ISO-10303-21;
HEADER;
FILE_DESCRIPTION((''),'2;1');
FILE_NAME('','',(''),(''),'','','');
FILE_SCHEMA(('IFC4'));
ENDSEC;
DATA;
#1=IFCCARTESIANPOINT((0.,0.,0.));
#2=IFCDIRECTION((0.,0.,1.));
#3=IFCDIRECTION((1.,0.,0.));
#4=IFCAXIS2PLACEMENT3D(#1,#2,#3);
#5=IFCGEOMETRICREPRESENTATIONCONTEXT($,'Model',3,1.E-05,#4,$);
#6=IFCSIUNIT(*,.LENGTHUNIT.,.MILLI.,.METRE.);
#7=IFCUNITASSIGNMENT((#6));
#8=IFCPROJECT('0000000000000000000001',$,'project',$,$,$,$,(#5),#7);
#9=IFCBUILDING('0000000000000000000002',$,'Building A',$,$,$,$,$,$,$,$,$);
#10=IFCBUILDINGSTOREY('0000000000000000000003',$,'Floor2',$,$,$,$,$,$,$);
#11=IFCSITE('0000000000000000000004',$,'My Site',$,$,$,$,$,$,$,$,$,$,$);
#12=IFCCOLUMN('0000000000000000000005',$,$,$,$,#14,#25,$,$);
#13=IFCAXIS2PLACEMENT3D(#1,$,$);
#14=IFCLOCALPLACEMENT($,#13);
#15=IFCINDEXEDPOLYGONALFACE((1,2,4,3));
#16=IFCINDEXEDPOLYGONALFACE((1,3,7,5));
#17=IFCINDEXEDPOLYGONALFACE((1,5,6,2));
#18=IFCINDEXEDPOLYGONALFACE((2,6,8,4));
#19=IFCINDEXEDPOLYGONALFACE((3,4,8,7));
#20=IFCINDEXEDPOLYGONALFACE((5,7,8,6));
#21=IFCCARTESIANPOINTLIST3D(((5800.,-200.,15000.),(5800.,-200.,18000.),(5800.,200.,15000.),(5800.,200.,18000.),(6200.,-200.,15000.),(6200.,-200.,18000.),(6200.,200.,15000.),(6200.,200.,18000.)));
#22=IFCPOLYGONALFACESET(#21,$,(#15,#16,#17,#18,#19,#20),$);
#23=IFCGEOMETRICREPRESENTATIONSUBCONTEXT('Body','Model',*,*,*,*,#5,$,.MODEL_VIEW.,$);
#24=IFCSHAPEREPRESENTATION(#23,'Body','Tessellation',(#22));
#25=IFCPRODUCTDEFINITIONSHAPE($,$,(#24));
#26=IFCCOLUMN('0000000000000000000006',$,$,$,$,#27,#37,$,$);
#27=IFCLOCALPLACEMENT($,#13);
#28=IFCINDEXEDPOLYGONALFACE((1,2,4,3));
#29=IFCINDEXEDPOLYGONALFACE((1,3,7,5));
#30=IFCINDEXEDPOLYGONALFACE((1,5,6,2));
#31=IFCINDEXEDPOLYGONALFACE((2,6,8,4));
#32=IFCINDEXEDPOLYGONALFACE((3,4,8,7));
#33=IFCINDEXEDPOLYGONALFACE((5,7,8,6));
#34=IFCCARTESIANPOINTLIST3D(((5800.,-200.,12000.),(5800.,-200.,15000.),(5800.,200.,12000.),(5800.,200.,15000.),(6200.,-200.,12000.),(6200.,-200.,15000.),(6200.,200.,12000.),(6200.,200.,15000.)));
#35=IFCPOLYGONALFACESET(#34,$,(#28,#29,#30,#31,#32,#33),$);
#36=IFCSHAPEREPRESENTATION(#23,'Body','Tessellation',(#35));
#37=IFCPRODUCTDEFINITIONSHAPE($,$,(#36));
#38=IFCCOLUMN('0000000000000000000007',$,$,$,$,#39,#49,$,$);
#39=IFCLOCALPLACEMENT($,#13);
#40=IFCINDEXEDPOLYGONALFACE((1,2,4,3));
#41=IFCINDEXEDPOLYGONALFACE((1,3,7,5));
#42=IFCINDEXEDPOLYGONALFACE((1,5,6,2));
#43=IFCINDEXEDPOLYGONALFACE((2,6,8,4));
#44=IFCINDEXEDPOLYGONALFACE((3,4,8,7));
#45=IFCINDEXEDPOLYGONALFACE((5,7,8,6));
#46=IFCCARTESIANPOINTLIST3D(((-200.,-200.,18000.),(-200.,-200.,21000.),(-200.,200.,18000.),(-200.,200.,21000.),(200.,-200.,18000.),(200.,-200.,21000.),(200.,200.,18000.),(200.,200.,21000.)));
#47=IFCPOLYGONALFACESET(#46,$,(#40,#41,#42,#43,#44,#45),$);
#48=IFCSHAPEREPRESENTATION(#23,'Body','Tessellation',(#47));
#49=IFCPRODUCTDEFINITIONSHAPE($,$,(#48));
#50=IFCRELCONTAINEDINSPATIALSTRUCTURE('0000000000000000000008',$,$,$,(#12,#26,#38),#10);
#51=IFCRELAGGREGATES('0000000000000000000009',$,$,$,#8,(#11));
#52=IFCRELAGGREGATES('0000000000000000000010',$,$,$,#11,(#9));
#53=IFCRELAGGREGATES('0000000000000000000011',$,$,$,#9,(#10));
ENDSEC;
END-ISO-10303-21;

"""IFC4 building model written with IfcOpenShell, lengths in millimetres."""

from ifc_helpers import new_model, si_unit, frame, origin_with_axes, place, context, subcontext, project, spatial, line, indexed_curve, outline, extrude, element, save


model = new_model("IFC4")

# Units and contexts
model_context = context("Model", 3, precision=1e-05, world=origin_with_axes())
body_context = subcontext(model_context, "Body", "Model", "MODEL_VIEW")
ifc_project = project(units=[si_unit("LENGTHUNIT", "METRE", prefix="MILLI")], contexts=[model_context])

# Site, building, storey
site = spatial("IfcSite", under=ifc_project, Name="My Site")
building = spatial("IfcBuilding", under=site, Name="Building A")
storey = spatial("IfcBuildingStorey", under=building, Name="Floor2")

# Columns
for number, where, z_axis, x_axis in (
    (1, (6000.0, 0.0, 15000.0), (0.0, 0.0, 1.0), (1.0, 0.0, 0.0)),
    (2, (6000.0, 0.0, 12000.0), (0.0, 0.0, 1.0), (1.0, 0.0, 0.0)),
    (3, (0.0, 0.0, 18000.0), (0.0, 0.0, 1.0), (1.0, 0.0, 0.0)),
):
    element("IfcColumn", number, at=place(None, frame(where, z_axis=z_axis, x_axis=x_axis)), inside=storey, context=body_context, shape_type="SweptSolid", body=[
        extrude(outline(indexed_curve([(-200.0, -200.0), (200.0, -200.0), (200.0, 200.0), (-200.0, 200.0)], segments=[line(1, 2, 3, 4, 1)])), origin_with_axes(), (0.0, 0.0, 1.0), 3000.0),
    ])

save(model, "model.ifc")
